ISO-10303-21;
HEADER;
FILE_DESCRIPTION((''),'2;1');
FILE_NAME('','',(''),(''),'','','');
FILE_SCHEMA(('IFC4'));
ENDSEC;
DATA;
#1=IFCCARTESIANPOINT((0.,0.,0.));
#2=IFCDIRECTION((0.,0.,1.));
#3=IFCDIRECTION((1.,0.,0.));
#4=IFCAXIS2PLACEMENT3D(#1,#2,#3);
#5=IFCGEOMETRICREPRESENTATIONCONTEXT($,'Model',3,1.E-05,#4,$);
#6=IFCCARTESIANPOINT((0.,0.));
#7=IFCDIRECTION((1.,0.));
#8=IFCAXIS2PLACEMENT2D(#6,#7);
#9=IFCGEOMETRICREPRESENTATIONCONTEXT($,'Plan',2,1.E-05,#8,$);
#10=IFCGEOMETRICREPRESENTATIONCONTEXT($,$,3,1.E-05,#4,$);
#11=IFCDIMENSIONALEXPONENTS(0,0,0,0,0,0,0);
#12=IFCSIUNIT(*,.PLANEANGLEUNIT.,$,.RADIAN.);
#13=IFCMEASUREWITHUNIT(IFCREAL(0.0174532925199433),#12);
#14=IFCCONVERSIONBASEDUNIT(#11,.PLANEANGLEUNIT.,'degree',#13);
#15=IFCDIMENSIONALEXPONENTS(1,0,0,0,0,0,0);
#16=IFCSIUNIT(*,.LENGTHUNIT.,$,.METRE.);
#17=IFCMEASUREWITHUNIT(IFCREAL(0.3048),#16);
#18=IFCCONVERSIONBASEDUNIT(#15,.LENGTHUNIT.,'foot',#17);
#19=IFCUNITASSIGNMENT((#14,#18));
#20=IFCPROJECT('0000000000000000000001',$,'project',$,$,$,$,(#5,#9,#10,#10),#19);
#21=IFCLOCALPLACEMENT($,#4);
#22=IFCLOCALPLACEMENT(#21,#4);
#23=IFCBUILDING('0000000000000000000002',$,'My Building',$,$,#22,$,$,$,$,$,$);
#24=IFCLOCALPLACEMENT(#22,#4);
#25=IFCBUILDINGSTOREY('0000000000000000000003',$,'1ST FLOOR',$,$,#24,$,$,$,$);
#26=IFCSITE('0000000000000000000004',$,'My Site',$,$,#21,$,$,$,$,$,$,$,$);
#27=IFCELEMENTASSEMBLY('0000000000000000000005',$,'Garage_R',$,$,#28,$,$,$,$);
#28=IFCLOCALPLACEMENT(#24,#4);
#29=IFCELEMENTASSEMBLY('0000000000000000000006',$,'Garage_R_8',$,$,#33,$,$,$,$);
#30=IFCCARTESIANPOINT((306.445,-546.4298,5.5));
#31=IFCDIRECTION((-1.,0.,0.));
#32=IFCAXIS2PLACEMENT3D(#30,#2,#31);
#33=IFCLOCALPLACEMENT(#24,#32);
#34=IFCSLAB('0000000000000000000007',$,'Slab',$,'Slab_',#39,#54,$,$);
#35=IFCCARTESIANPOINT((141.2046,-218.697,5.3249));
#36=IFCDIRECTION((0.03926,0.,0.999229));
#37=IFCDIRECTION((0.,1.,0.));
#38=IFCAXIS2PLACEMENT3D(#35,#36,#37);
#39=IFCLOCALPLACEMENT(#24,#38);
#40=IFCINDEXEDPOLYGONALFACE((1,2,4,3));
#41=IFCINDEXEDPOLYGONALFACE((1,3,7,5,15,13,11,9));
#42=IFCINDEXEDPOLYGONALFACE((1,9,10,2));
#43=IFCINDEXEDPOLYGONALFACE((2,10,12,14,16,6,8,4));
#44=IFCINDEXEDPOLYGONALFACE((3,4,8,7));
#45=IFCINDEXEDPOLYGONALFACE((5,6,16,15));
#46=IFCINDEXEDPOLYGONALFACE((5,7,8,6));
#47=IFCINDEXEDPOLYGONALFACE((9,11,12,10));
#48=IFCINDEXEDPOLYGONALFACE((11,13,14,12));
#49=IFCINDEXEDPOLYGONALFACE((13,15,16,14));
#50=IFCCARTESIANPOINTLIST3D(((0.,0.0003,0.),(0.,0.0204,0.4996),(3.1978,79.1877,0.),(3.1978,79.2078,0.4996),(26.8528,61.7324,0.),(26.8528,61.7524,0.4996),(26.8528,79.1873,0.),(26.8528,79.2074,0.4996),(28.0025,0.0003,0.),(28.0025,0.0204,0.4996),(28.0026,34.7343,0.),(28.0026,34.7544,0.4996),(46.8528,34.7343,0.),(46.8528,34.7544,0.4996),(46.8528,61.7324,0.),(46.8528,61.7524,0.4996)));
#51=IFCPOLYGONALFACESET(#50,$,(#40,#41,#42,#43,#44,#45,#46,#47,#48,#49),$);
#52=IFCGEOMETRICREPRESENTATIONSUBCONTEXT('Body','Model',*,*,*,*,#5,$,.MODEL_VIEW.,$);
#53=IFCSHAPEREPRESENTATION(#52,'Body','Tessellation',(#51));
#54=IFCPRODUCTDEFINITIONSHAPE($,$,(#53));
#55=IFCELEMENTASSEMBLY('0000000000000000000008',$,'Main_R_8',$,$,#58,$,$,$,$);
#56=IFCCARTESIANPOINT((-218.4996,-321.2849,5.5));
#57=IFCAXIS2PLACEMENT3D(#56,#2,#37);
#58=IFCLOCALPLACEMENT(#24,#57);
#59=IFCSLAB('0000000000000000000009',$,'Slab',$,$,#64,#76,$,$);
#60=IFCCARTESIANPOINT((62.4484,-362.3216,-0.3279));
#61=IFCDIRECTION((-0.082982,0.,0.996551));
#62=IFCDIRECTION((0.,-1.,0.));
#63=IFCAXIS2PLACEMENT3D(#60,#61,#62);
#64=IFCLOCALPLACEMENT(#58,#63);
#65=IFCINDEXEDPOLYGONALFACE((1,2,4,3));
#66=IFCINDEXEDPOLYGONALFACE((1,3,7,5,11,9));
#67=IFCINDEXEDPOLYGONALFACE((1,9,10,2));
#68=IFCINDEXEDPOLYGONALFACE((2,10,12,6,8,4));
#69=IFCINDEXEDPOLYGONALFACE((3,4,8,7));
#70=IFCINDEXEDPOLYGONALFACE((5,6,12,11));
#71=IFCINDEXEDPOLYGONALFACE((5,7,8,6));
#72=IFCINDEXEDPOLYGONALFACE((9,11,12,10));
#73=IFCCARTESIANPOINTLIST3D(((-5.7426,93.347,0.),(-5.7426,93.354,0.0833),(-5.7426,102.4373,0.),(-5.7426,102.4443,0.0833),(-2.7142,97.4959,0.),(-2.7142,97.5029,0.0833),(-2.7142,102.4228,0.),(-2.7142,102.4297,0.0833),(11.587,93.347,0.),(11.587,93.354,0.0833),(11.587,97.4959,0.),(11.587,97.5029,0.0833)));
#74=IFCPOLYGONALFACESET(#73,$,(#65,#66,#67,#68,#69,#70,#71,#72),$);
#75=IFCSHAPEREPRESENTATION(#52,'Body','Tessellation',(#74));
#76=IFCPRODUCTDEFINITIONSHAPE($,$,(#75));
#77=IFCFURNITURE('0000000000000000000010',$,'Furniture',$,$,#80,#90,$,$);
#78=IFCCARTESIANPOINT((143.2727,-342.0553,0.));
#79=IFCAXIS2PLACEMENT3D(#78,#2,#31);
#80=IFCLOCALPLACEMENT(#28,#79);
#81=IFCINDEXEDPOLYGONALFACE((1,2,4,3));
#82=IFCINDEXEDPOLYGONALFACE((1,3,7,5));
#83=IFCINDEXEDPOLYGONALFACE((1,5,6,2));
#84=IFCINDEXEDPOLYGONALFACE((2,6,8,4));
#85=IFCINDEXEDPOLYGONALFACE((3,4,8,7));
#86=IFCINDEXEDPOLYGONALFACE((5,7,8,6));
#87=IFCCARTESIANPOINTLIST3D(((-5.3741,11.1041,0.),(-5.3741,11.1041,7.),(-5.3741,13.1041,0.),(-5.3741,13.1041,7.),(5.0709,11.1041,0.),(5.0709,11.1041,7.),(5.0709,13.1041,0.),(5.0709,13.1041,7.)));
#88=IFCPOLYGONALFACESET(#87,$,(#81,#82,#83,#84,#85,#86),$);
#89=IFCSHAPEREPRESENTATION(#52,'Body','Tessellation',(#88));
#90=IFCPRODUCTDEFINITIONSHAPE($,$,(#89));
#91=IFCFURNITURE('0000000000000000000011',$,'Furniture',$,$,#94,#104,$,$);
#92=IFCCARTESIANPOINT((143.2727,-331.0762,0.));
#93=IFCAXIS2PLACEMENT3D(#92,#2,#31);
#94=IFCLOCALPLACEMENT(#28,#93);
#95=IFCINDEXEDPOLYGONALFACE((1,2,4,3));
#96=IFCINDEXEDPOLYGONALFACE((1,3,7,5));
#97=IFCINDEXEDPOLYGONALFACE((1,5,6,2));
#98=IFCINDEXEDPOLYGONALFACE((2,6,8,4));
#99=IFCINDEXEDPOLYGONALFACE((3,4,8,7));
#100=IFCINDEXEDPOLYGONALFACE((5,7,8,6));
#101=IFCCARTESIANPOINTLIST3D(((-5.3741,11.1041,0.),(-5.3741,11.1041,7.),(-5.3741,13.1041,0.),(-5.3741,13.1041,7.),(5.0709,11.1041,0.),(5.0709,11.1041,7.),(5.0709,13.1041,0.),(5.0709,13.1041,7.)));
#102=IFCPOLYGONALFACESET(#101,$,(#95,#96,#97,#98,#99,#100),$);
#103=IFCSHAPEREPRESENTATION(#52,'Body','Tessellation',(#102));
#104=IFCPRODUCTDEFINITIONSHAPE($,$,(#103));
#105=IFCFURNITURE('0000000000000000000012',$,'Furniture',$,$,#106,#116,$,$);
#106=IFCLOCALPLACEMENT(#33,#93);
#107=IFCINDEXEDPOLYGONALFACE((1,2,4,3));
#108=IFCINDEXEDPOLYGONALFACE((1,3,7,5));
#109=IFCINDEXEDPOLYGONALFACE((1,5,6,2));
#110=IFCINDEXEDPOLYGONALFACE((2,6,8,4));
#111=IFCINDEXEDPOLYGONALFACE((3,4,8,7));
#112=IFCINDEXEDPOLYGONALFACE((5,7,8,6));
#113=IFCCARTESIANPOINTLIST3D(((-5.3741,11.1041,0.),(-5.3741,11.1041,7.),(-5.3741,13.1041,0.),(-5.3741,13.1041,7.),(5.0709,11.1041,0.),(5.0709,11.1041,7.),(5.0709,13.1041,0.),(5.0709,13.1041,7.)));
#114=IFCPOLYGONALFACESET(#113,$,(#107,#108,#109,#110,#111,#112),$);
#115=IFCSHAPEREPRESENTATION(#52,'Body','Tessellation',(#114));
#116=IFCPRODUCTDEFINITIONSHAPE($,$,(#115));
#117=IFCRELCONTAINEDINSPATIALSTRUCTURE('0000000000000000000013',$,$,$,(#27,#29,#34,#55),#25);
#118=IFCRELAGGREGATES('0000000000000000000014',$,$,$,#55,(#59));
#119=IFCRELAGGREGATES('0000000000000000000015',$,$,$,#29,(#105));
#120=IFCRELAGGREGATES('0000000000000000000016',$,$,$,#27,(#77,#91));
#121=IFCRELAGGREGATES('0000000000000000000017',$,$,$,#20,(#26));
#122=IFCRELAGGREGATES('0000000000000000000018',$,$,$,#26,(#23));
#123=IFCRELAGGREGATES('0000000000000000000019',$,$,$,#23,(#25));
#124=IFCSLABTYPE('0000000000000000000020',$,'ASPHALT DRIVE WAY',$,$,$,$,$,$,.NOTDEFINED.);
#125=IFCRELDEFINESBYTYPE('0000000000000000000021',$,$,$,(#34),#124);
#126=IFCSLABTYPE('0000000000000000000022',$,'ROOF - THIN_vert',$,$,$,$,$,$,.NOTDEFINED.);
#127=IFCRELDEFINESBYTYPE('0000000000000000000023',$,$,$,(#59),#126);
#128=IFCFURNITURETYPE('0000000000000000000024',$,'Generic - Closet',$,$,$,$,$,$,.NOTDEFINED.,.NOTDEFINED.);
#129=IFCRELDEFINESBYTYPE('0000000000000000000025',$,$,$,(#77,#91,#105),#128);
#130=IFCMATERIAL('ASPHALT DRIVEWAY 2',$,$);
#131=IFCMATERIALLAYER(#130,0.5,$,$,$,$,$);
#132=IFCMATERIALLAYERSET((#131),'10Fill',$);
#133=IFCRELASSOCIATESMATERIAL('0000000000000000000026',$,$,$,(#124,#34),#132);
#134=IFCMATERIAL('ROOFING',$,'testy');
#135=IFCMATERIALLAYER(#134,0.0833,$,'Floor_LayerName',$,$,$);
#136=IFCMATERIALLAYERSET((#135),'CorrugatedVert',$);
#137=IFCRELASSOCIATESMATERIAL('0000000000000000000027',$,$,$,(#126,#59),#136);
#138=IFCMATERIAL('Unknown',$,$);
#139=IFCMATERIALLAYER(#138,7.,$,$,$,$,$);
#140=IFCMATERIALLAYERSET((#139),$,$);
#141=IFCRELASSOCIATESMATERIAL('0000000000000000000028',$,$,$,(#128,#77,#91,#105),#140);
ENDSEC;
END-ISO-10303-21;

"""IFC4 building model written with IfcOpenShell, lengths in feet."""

from ifc_helpers import new_model, entity, si_unit, converted_unit, frame, origin_with_axes, origin_2d_with_axis, place, context, subcontext, project, spatial, line, indexed_curve, outline, extrude, material, layer, layer_set, layer_usage, type_object, element, aggregate, save


model = new_model("IFC4")

# Units and contexts
model_context = context("Model", 3, precision=1e-05, world=origin_with_axes())
plan_context = context("Plan", 2, precision=1e-05, world=origin_2d_with_axis())
context_of_model = context(None, 3, precision=1e-05, world=origin_with_axes())
body_context = subcontext(model_context, "Body", "Model", "MODEL_VIEW")
ifc_project = project(units=[converted_unit("PLANEANGLEUNIT", "degree", entity("IfcReal", 0.0174532925199433), si_unit("PLANEANGLEUNIT", "RADIAN"), dimensions=[0, 0, 0, 0, 0, 0, 0]), converted_unit("LENGTHUNIT", "foot", entity("IfcReal", 0.3048), si_unit("LENGTHUNIT", "METRE"), dimensions=[1, 0, 0, 0, 0, 0, 0])], contexts=[model_context, plan_context, context_of_model, context_of_model])

# Site, building, storey
site_placement = place(None, origin_with_axes())
site = spatial("IfcSite", under=ifc_project, at=site_placement, Name="My Site")
building_placement = place(site_placement, origin_with_axes())
building = spatial("IfcBuilding", under=site, at=building_placement, Name="My Building")
storey_placement = place(building_placement, origin_with_axes())
storey = spatial("IfcBuildingStorey", under=building, at=storey_placement, Name="1ST FLOOR")

# Element assembly
assembly_1_placement = place(storey_placement, origin_with_axes())
assembly_1 = element("IfcElementAssembly", 1, at=assembly_1_placement, inside=storey, Name="Garage_R")
ifc_material_1 = material(Name="Unknown")

# Element assembly
assembly_2_placement = place(storey_placement, frame((306.445, -546.4298, 5.5), z_axis=(0.0, 0.0, 1.0), x_axis=(-1.0, 0.0, 0.0)))
assembly_2 = element("IfcElementAssembly", 2, at=assembly_2_placement, inside=storey, Name="Garage_R_8")

# Slab
ifc_material_2 = material(Name="ASPHALT DRIVEWAY 2")
ifc_layer_1 = layer(ifc_material_2, 0.5)
ifc_layer_set_1 = layer_set([ifc_layer_1], Name="10Fill")
ifc_layer_usage_1 = layer_usage(ifc_layer_set_1, "AXIS3", "POSITIVE", 0.0)
slab_type_1 = type_object("IfcSlabType", Name="ASPHALT DRIVE WAY", PredefinedType="NOTDEFINED", material=ifc_layer_set_1)
slab_1_placement = place(storey_placement, frame((141.2046, -218.697, 5.3249), z_axis=(0.03926, 0.0, 0.999229), x_axis=(0.0, 1.0, 0.0)))
element("IfcSlab", 3, at=slab_1_placement, inside=storey, type_object=slab_type_1, material=ifc_layer_usage_1, Name="Slab", ObjectType="Slab_", context=body_context, shape_type="SweptSolid", body=[
    extrude(outline(indexed_curve([(46.8528, 34.7343), (46.8528, 61.7324), (26.8528, 61.7324), (26.8528, 79.1873), (3.1978, 79.1877), (0.0, 0.0003), (28.0025, 0.0003), (28.0026, 34.7343)], segments=[line(5, 6), line(6, 7), line(7, 8), line(8, 1), line(1, 2), line(2, 3), line(3, 4), line(4, 5)], self_intersect=False)), None, (0.0, 0.040132, 0.999194), 0.5),
])

# Element assembly, slab
assembly_3_placement = place(storey_placement, frame((-218.4996, -321.2849, 5.5), z_axis=(0.0, 0.0, 1.0), x_axis=(0.0, 1.0, 0.0)))
assembly_3 = element("IfcElementAssembly", 4, at=assembly_3_placement, inside=storey, Name="Main_R_8")
ifc_material_3 = material(Name="ROOFING", Category="testy")
ifc_layer_2 = layer(ifc_material_3, 0.0833, Name="Floor_LayerName")
ifc_layer_set_2 = layer_set([ifc_layer_2], Name="CorrugatedVert")
ifc_layer_usage_2 = layer_usage(ifc_layer_set_2, "AXIS3", "POSITIVE", 0.0)
slab_type_2 = type_object("IfcSlabType", Name="ROOF - THIN_vert", PredefinedType="NOTDEFINED", material=ifc_layer_set_2)
slab_2_placement = place(assembly_3_placement, frame((62.4484, -362.3216, -0.3279), z_axis=(-0.082982, 0.0, 0.996551), x_axis=(0.0, -1.0, 0.0)))
slab_2 = element("IfcSlab", 5, at=slab_2_placement, type_object=slab_type_2, material=ifc_layer_usage_2, Name="Slab", context=body_context, shape_type="SweptSolid", body=[
    extrude(outline(indexed_curve([(11.587, 93.347), (11.587, 97.4959), (-2.7142, 97.4959), (-2.7142, 102.4228), (-5.7426, 102.4373), (-5.7426, 93.347)], segments=[line(1, 6), line(6, 5), line(5, 4), line(4, 3), line(3, 2), line(2, 1)], self_intersect=False)), None, (0.0, 0.082982, 0.996551), 0.0836),
])
aggregate(assembly_3, [slab_2])

# Furniture
ifc_layer_3 = layer(ifc_material_1, 7.0)
ifc_layer_set_3 = layer_set([ifc_layer_3])
ifc_layer_usage_3 = layer_usage(ifc_layer_set_3, "AXIS3", "POSITIVE", 0.0)
furniture_type = type_object("IfcFurnitureType", Name="Generic - Closet", AssemblyPlace="NOTDEFINED", PredefinedType="NOTDEFINED", material=ifc_layer_set_3)
furniture_1_placement = place(assembly_1_placement, frame((143.2727, -342.0553, 0.0), z_axis=(0.0, 0.0, 1.0), x_axis=(-1.0, 0.0, 0.0)))
furniture_1 = element("IfcFurniture", 6, at=furniture_1_placement, type_object=furniture_type, material=ifc_layer_usage_3, Name="Furniture", context=body_context, shape_type="SweptSolid", body=[
    extrude(outline(indexed_curve([(5.0709, 11.1041), (5.0709, 13.1041), (-5.3741, 13.1041), (-5.3741, 11.1041)], segments=[line(3, 2), line(2, 1), line(1, 4), line(4, 3)], self_intersect=False)), None, (0.0, 0.0, 1.0), 7.0),
])
ifc_layer_usage_4 = layer_usage(ifc_layer_set_3, "AXIS3", "POSITIVE", 0.0)
furniture_2_placement = place(assembly_1_placement, frame((143.2727, -331.0762, 0.0), z_axis=(0.0, 0.0, 1.0), x_axis=(-1.0, 0.0, 0.0)))
furniture_2 = element("IfcFurniture", 7, at=furniture_2_placement, type_object=furniture_type, material=ifc_layer_usage_4, Name="Furniture", context=body_context, shape_type="SweptSolid", body=[
    extrude(outline(indexed_curve([(5.0709, 13.1041), (-5.3741, 13.1041), (-5.3741, 11.1041), (5.0709, 11.1041)], segments=[line(4, 1), line(1, 2), line(2, 3), line(3, 4)], self_intersect=False)), None, (0.0, 0.0, 1.0), 7.0),
])
ifc_layer_usage_5 = layer_usage(ifc_layer_set_3, "AXIS3", "POSITIVE", 0.0)
furniture_3_placement = place(assembly_2_placement, frame((143.2727, -331.0762, 0.0), z_axis=(0.0, 0.0, 1.0), x_axis=(-1.0, 0.0, 0.0)))
furniture_3 = element("IfcFurniture", 8, at=furniture_3_placement, type_object=furniture_type, material=ifc_layer_usage_5, Name="Furniture", context=body_context, shape_type="SweptSolid", body=[
    extrude(outline(indexed_curve([(5.0709, 13.1041), (-5.3741, 13.1041), (-5.3741, 11.1041), (5.0709, 11.1041)], segments=[line(4, 1), line(1, 2), line(2, 3), line(3, 4)], self_intersect=False)), None, (0.0, 0.0, 1.0), 7.0),
])
aggregate(assembly_2, [furniture_3])

aggregate(assembly_1, [furniture_1, furniture_2])

save(model, "model.ifc")
